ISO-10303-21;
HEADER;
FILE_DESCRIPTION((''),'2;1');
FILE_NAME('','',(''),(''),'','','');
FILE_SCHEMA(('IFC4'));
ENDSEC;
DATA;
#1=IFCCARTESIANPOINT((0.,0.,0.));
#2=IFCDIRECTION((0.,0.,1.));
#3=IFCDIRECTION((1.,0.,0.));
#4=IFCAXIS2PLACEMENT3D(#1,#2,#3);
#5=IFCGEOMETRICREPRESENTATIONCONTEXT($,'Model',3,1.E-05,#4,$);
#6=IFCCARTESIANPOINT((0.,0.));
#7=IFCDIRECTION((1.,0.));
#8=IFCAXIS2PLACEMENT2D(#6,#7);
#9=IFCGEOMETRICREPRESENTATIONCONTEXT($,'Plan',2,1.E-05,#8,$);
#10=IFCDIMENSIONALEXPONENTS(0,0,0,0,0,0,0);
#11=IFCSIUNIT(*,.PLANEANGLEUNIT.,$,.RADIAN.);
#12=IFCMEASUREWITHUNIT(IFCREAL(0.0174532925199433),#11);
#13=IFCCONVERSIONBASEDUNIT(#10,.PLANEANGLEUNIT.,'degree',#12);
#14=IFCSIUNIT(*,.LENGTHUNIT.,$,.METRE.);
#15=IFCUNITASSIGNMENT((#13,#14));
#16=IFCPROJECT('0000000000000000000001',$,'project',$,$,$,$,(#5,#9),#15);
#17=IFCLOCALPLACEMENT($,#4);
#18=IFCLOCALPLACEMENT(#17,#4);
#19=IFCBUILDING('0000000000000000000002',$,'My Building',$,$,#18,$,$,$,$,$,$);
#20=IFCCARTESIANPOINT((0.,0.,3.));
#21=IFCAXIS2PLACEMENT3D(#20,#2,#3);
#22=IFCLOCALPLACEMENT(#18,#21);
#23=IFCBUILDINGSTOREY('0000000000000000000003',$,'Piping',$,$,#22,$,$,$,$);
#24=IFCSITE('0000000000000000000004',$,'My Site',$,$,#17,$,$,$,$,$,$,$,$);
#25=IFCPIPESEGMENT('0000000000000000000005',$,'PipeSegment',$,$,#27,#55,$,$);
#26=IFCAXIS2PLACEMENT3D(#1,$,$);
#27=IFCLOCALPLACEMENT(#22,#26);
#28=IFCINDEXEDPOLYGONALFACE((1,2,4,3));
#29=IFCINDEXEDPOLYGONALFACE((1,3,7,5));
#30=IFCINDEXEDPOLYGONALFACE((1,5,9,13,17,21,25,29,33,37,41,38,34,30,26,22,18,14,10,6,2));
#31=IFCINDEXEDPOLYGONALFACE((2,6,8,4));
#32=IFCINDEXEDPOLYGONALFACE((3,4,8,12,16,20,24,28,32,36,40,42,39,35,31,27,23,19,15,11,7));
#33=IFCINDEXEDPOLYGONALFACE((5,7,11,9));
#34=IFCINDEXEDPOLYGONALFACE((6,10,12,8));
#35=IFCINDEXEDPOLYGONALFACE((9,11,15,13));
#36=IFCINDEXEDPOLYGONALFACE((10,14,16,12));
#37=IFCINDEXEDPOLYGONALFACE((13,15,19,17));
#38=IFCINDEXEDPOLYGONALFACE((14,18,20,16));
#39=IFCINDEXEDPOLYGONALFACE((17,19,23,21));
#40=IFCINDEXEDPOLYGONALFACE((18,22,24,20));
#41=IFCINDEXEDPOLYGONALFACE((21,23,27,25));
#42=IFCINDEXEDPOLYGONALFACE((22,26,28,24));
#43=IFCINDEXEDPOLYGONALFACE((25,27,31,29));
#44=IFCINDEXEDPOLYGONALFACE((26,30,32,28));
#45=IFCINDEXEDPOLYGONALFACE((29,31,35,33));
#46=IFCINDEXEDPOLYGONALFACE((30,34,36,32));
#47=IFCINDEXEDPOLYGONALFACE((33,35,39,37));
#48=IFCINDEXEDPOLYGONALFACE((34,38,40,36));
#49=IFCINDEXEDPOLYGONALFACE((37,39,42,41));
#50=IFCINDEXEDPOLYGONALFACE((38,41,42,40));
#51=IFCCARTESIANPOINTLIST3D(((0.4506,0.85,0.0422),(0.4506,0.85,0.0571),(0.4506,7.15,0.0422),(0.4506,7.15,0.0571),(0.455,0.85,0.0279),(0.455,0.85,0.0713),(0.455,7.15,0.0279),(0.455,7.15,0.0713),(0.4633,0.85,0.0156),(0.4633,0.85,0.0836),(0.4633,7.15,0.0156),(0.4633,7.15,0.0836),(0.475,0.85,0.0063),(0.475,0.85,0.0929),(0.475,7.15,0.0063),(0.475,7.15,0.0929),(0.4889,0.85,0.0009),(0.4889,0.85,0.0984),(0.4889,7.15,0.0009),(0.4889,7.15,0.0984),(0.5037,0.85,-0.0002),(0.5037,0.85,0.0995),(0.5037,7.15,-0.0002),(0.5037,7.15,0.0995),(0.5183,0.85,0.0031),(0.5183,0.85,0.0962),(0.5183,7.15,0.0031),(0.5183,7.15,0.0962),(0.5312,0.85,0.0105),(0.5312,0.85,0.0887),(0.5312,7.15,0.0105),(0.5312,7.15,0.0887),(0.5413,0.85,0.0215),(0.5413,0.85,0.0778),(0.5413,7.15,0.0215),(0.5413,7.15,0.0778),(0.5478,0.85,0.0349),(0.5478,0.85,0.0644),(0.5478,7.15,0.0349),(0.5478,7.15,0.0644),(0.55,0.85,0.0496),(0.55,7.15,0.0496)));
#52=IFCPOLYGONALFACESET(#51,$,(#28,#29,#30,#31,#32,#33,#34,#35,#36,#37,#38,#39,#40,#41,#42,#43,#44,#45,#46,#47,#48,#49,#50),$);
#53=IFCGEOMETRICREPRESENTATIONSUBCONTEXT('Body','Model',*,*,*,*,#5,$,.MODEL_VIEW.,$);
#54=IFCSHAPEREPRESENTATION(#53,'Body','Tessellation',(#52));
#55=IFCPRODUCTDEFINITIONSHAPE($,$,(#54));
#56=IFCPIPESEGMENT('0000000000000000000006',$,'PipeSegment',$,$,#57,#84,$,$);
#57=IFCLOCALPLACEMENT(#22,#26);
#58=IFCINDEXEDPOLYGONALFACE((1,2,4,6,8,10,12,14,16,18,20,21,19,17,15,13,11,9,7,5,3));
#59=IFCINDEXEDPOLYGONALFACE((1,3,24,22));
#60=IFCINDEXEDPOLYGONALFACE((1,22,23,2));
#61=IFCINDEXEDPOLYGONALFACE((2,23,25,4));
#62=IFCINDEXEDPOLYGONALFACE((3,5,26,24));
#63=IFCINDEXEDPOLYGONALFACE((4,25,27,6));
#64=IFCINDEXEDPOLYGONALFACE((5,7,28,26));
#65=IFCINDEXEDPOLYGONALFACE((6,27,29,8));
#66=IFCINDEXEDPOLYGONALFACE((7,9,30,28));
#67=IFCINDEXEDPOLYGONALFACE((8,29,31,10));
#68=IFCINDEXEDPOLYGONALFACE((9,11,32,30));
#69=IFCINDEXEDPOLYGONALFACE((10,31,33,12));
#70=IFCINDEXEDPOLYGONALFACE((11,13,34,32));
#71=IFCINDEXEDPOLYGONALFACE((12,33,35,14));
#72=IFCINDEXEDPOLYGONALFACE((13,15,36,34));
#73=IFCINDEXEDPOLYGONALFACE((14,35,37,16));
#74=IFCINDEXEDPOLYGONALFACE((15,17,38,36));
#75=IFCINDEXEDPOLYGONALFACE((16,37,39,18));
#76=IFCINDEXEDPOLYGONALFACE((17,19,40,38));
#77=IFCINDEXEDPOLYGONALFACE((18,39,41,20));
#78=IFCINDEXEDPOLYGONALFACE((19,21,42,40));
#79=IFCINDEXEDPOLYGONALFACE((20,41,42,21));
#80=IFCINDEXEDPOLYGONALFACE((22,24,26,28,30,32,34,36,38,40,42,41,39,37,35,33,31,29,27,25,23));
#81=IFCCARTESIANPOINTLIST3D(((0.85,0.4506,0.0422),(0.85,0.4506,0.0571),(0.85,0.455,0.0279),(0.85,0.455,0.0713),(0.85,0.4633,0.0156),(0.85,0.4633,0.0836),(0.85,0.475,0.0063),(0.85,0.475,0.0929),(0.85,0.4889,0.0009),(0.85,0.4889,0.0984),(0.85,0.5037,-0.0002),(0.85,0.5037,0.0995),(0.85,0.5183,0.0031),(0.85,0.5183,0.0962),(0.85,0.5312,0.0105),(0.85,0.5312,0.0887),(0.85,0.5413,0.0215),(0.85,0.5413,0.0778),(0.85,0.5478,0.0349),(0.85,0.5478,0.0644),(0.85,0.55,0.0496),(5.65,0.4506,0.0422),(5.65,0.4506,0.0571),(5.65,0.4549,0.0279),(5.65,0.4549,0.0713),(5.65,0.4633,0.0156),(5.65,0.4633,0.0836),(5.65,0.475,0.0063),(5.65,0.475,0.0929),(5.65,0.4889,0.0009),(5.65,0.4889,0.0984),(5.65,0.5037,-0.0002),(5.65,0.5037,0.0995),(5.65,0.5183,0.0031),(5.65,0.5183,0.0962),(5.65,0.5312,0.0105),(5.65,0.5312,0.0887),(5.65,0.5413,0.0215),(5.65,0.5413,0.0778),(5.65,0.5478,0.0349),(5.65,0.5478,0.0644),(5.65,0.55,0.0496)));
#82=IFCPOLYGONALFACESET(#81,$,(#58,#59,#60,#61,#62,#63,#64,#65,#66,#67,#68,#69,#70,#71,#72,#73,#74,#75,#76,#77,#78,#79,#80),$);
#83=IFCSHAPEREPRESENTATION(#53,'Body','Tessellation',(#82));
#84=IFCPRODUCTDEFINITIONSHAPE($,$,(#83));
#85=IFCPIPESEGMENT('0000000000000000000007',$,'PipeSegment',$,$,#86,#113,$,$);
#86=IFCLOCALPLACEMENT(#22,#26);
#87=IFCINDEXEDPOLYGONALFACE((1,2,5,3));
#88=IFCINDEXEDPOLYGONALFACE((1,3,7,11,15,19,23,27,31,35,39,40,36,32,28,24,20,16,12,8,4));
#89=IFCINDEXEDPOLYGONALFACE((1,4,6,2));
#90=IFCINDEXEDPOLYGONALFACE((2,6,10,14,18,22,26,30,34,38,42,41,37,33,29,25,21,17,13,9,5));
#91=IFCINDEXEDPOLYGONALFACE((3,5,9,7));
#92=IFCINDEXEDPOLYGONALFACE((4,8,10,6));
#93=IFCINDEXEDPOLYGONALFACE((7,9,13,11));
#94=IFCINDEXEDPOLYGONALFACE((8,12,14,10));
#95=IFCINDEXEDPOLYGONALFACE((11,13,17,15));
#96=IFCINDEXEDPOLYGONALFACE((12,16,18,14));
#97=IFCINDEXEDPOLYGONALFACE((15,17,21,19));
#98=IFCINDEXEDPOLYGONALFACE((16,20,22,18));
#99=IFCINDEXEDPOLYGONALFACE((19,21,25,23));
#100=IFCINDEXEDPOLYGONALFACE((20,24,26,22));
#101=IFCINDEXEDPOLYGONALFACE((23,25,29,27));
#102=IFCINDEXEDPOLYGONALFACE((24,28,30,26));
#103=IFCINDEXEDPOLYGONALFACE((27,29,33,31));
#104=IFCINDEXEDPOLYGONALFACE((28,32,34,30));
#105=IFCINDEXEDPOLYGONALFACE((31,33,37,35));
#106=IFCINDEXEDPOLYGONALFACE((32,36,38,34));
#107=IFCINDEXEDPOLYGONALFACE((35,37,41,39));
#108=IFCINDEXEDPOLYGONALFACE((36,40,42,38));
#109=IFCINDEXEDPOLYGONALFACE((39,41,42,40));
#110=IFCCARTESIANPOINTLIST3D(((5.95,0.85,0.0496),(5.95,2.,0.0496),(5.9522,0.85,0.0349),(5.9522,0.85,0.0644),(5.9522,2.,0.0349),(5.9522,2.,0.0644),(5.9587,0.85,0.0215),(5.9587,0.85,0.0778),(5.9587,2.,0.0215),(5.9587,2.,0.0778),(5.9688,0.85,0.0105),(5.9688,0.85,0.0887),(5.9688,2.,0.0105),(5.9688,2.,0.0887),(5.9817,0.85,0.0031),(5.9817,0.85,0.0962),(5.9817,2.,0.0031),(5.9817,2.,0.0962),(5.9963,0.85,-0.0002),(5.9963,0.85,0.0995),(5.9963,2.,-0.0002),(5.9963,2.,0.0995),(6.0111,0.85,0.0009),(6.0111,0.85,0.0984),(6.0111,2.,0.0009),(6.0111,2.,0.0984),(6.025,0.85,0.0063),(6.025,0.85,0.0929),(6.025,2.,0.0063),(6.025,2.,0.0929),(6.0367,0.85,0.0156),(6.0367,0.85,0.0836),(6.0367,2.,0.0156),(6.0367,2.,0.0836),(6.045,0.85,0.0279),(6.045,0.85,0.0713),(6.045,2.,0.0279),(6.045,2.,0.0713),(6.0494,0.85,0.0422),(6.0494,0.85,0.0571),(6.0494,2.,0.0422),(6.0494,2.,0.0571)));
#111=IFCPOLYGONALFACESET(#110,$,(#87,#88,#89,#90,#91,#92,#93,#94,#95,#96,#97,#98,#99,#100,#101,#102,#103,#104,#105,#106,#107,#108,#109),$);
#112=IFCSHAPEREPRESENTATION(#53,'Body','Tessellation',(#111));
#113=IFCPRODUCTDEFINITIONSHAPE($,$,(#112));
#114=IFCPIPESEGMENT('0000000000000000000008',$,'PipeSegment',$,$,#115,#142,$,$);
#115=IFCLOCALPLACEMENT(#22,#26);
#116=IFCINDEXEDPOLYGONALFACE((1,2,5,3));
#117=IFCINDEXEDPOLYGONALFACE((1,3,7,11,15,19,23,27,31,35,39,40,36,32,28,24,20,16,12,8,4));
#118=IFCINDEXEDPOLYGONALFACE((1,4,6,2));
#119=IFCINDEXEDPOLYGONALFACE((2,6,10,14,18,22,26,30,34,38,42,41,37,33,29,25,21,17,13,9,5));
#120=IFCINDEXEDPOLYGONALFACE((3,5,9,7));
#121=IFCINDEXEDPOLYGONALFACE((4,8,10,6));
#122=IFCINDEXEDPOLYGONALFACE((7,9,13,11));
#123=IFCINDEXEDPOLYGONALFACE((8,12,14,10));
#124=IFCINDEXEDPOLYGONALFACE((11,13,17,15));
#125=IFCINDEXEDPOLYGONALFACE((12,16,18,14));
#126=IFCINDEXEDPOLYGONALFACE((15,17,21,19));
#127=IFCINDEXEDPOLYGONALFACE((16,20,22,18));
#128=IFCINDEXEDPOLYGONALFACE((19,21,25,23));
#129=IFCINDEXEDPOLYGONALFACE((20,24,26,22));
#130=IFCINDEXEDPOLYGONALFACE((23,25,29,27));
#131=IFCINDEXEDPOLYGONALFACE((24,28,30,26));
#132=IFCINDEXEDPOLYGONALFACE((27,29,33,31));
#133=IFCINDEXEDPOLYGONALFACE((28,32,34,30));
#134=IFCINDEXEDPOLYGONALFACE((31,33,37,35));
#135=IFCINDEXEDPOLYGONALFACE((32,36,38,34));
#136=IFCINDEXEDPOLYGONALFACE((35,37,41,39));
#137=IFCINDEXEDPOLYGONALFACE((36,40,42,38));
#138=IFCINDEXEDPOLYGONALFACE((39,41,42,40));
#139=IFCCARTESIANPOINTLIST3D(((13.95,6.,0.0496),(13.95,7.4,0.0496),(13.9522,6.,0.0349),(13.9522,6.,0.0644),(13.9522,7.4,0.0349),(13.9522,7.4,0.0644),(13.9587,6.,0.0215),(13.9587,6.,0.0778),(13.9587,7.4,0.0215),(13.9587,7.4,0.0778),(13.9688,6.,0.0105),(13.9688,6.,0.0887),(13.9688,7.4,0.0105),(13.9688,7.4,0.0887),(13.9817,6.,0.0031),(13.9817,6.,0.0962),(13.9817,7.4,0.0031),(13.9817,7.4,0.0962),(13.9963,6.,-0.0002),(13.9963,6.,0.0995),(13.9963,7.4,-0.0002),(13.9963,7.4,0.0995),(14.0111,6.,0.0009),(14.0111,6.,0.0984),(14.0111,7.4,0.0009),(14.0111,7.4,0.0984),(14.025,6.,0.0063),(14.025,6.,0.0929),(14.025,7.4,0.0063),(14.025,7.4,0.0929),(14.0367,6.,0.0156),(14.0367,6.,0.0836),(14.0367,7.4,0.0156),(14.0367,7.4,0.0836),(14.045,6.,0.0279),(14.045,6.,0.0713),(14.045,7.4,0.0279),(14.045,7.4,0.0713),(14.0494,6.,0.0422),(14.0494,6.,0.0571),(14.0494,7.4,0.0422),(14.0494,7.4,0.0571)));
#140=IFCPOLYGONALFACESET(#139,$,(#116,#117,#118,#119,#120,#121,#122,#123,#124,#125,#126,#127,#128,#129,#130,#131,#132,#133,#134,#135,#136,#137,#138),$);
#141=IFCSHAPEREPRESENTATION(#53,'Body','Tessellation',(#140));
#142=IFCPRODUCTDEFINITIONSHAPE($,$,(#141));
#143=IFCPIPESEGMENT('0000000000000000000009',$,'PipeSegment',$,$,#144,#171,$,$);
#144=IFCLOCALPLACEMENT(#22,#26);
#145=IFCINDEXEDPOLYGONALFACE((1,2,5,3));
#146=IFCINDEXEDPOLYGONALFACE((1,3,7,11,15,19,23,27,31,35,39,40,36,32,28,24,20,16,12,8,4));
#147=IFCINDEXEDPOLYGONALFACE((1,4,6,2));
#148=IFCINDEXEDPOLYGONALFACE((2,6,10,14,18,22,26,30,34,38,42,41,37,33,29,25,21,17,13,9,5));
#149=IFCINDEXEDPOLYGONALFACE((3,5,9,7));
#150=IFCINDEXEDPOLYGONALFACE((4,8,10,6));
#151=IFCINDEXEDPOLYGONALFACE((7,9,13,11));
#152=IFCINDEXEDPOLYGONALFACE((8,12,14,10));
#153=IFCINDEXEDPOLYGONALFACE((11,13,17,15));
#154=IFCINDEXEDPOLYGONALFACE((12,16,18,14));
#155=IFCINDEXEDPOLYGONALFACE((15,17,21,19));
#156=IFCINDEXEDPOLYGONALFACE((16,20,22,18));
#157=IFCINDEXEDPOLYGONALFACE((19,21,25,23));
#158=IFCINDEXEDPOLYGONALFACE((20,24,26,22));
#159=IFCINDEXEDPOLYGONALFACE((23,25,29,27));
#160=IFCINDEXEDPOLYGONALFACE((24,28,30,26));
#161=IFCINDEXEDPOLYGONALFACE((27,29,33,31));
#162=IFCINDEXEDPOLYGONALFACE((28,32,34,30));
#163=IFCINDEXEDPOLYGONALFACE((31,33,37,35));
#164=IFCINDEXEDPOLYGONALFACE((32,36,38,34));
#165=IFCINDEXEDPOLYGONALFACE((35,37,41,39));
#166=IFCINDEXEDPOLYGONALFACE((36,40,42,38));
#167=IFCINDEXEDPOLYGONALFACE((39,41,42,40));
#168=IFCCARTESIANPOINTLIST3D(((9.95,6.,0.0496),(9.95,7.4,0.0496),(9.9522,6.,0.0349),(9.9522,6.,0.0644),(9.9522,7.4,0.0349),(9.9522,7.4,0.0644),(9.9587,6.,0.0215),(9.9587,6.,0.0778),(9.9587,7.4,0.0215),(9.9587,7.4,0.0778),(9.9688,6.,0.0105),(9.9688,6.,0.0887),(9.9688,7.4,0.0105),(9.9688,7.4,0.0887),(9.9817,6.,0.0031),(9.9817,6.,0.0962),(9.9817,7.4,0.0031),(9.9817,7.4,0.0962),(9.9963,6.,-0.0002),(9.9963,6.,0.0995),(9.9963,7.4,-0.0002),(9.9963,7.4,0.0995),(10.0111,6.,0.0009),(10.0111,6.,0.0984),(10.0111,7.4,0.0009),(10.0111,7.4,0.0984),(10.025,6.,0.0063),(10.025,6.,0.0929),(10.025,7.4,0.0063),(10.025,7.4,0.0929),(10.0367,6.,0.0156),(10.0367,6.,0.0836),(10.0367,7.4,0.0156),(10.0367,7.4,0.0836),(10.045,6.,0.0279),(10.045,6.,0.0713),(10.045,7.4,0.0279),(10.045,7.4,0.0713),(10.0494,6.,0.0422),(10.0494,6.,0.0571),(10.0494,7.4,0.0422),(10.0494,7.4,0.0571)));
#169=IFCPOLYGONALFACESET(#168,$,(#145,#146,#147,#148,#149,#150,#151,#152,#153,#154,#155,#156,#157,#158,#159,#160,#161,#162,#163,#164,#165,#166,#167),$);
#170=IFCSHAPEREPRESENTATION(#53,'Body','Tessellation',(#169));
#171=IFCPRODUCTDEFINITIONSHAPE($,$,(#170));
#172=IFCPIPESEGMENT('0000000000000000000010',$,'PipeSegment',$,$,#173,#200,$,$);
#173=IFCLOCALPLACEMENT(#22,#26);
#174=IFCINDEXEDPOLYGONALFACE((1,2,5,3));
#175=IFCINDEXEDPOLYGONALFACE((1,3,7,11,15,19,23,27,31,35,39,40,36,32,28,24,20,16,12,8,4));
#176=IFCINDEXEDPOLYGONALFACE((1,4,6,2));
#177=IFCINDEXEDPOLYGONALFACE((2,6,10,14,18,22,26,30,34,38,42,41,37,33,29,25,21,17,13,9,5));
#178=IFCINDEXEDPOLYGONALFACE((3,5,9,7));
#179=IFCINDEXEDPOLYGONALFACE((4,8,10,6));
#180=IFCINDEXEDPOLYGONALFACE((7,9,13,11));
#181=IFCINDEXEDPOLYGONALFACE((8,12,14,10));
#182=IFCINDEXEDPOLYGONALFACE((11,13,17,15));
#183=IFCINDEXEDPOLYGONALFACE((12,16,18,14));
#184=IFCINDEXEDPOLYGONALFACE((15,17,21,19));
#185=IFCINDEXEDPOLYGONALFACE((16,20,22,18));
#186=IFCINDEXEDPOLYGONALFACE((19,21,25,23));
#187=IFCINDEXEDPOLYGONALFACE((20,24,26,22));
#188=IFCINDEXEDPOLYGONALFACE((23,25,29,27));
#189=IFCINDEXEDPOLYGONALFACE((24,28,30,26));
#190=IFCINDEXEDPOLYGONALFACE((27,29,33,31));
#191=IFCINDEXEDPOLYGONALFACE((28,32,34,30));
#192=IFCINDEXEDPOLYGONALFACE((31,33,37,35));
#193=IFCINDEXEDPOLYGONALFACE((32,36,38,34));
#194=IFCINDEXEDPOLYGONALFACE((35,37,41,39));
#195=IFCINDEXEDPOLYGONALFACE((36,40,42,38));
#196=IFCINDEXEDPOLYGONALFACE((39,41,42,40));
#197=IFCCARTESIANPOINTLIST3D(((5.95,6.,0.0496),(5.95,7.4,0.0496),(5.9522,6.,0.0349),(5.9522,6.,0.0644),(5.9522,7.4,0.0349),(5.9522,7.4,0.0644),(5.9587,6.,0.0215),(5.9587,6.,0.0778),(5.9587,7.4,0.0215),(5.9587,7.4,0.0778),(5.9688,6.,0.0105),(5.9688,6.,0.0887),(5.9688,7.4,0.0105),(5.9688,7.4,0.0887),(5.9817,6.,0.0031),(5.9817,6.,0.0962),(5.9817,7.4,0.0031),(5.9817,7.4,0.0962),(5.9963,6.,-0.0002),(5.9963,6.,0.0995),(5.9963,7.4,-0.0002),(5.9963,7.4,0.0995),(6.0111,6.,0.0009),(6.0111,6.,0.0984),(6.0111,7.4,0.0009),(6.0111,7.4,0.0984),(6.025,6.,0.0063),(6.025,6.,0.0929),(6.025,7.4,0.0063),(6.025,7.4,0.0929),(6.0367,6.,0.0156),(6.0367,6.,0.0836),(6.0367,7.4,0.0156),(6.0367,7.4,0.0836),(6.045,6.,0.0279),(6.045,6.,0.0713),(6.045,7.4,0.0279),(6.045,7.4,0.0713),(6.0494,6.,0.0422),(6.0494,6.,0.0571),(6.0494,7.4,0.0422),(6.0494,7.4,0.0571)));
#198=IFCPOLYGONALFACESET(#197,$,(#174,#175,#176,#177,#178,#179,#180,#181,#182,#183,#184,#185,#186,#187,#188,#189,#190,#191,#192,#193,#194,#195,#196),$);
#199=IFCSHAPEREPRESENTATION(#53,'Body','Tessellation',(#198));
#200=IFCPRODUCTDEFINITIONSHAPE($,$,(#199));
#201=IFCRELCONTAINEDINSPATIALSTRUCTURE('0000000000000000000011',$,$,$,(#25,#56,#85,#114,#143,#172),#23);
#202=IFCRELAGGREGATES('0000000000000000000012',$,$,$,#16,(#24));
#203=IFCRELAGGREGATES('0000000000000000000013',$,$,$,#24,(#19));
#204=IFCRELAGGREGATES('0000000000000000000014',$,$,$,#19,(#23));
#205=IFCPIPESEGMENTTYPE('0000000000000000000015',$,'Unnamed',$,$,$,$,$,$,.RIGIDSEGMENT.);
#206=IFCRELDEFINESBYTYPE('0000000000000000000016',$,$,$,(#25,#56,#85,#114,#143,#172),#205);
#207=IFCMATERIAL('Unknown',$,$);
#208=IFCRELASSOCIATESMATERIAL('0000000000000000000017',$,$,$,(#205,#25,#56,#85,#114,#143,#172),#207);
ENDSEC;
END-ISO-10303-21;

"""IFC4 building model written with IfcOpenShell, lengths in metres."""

from ifc_helpers import new_model, entity, si_unit, converted_unit, frame, origin_with_axes, origin_2d_with_axis, place, context, subcontext, project, spatial, circle, extrude, material, material_profile, profile_set, profile_usage, type_object, element, save


model = new_model("IFC4")

# Units and contexts
model_context = context("Model", 3, precision=1e-05, world=origin_with_axes())
plan_context = context("Plan", 2, precision=1e-05, world=origin_2d_with_axis())
body_context = subcontext(model_context, "Body", "Model", "MODEL_VIEW")
ifc_project = project(units=[converted_unit("PLANEANGLEUNIT", "degree", entity("IfcReal", 0.0174532925199433), si_unit("PLANEANGLEUNIT", "RADIAN"), dimensions=[0, 0, 0, 0, 0, 0, 0]), si_unit("LENGTHUNIT", "METRE")], contexts=[model_context, plan_context])

# Site, building, storey
site_placement = place(None, origin_with_axes())
site = spatial("IfcSite", under=ifc_project, at=site_placement, Name="My Site")
building_placement = place(site_placement, origin_with_axes())
building = spatial("IfcBuilding", under=site, at=building_placement, Name="My Building")
storey_placement = place(building_placement, frame((0.0, 0.0, 3.0), z_axis=(0.0, 0.0, 1.0), x_axis=(1.0, 0.0, 0.0)))
storey = spatial("IfcBuildingStorey", under=building, at=storey_placement, Name="Piping")

# Shared definitions
ifc_material = material(Name="Unknown")

# Pipe segments
ifc_material_profile_1 = material_profile(ifc_material, circle(Radius=0.05))
ifc_profile_set_1 = profile_set([ifc_material_profile_1])
pipe_segment_type = type_object("IfcPipeSegmentType", Name="Unnamed", PredefinedType="RIGIDSEGMENT", material=ifc_profile_set_1)
ifc_profile_usage_1 = profile_usage(ifc_profile_set_1, cardinal=5)
pipe_segment_1_placement = place(storey_placement, frame((0.5, 7.15, 0.0496), z_axis=(0.0, -1.0, 0.0), x_axis=(1.0, 0.0, 0.0)))
element("IfcPipeSegment", 1, at=pipe_segment_1_placement, inside=storey, type_object=pipe_segment_type, material=ifc_profile_usage_1, Name="PipeSegment", context=body_context, shape_type="SweptSolid", body=[
    extrude(circle(Radius=0.05), origin_with_axes(), (0.0, 0.0, 1.0), 6.3),
])
ifc_profile_usage_2 = profile_usage(ifc_profile_set_1, cardinal=5)
pipe_segment_2_placement = place(storey_placement, frame((0.85, 0.5, 0.0496), z_axis=(1.0, -0.000001, 0.0), x_axis=(0.000001, 1.0, 0.0)))
element("IfcPipeSegment", 2, at=pipe_segment_2_placement, inside=storey, type_object=pipe_segment_type, material=ifc_profile_usage_2, Name="PipeSegment", context=body_context, shape_type="SweptSolid", body=[
    extrude(circle(Radius=0.05), origin_with_axes(), (0.0, 0.0, 1.0), 4.8),
])
ifc_profile_usage_3 = profile_usage(ifc_profile_set_1, cardinal=5)
pipe_segment_3_placement = place(storey_placement, frame((6.0, 0.85, 0.0496), z_axis=(0.0, 1.0, 0.0), x_axis=(-1.0, 0.0, 0.0)))
element("IfcPipeSegment", 3, at=pipe_segment_3_placement, inside=storey, type_object=pipe_segment_type, material=ifc_profile_usage_3, Name="PipeSegment", context=body_context, shape_type="SweptSolid", body=[
    extrude(circle(Radius=0.05), origin_with_axes(), (0.0, 0.0, 1.0), 1.15),
])
ifc_profile_usage_4 = profile_usage(ifc_profile_set_1, cardinal=5)
pipe_segment_4_placement = place(storey_placement, frame((14.0, 6.0, 0.0496), z_axis=(0.0, 1.0, 0.0), x_axis=(-1.0, 0.0, 0.0)))
element("IfcPipeSegment", 4, at=pipe_segment_4_placement, inside=storey, type_object=pipe_segment_type, material=ifc_profile_usage_4, Name="PipeSegment", context=body_context, shape_type="SweptSolid", body=[
    extrude(circle(Radius=0.05), origin_with_axes(), (0.0, 0.0, 1.0), 1.4),
])
ifc_profile_usage_5 = profile_usage(ifc_profile_set_1, cardinal=5)
pipe_segment_5_placement = place(storey_placement, frame((10.0, 6.0, 0.0496), z_axis=(0.0, 1.0, 0.0), x_axis=(-1.0, 0.0, 0.0)))
element("IfcPipeSegment", 5, at=pipe_segment_5_placement, inside=storey, type_object=pipe_segment_type, material=ifc_profile_usage_5, Name="PipeSegment", context=body_context, shape_type="SweptSolid", body=[
    extrude(circle(Radius=0.05), origin_with_axes(), (0.0, 0.0, 1.0), 1.4),
])
ifc_profile_usage_6 = profile_usage(ifc_profile_set_1, cardinal=5)
pipe_segment_6_placement = place(storey_placement, frame((6.0, 6.0, 0.0496), z_axis=(0.0, 1.0, 0.0), x_axis=(-1.0, 0.0, 0.0)))
element("IfcPipeSegment", 6, at=pipe_segment_6_placement, inside=storey, type_object=pipe_segment_type, material=ifc_profile_usage_6, Name="PipeSegment", context=body_context, shape_type="SweptSolid", body=[
    extrude(circle(Radius=0.05), origin_with_axes(), (0.0, 0.0, 1.0), 1.4),
])

save(model, "model.ifc")
